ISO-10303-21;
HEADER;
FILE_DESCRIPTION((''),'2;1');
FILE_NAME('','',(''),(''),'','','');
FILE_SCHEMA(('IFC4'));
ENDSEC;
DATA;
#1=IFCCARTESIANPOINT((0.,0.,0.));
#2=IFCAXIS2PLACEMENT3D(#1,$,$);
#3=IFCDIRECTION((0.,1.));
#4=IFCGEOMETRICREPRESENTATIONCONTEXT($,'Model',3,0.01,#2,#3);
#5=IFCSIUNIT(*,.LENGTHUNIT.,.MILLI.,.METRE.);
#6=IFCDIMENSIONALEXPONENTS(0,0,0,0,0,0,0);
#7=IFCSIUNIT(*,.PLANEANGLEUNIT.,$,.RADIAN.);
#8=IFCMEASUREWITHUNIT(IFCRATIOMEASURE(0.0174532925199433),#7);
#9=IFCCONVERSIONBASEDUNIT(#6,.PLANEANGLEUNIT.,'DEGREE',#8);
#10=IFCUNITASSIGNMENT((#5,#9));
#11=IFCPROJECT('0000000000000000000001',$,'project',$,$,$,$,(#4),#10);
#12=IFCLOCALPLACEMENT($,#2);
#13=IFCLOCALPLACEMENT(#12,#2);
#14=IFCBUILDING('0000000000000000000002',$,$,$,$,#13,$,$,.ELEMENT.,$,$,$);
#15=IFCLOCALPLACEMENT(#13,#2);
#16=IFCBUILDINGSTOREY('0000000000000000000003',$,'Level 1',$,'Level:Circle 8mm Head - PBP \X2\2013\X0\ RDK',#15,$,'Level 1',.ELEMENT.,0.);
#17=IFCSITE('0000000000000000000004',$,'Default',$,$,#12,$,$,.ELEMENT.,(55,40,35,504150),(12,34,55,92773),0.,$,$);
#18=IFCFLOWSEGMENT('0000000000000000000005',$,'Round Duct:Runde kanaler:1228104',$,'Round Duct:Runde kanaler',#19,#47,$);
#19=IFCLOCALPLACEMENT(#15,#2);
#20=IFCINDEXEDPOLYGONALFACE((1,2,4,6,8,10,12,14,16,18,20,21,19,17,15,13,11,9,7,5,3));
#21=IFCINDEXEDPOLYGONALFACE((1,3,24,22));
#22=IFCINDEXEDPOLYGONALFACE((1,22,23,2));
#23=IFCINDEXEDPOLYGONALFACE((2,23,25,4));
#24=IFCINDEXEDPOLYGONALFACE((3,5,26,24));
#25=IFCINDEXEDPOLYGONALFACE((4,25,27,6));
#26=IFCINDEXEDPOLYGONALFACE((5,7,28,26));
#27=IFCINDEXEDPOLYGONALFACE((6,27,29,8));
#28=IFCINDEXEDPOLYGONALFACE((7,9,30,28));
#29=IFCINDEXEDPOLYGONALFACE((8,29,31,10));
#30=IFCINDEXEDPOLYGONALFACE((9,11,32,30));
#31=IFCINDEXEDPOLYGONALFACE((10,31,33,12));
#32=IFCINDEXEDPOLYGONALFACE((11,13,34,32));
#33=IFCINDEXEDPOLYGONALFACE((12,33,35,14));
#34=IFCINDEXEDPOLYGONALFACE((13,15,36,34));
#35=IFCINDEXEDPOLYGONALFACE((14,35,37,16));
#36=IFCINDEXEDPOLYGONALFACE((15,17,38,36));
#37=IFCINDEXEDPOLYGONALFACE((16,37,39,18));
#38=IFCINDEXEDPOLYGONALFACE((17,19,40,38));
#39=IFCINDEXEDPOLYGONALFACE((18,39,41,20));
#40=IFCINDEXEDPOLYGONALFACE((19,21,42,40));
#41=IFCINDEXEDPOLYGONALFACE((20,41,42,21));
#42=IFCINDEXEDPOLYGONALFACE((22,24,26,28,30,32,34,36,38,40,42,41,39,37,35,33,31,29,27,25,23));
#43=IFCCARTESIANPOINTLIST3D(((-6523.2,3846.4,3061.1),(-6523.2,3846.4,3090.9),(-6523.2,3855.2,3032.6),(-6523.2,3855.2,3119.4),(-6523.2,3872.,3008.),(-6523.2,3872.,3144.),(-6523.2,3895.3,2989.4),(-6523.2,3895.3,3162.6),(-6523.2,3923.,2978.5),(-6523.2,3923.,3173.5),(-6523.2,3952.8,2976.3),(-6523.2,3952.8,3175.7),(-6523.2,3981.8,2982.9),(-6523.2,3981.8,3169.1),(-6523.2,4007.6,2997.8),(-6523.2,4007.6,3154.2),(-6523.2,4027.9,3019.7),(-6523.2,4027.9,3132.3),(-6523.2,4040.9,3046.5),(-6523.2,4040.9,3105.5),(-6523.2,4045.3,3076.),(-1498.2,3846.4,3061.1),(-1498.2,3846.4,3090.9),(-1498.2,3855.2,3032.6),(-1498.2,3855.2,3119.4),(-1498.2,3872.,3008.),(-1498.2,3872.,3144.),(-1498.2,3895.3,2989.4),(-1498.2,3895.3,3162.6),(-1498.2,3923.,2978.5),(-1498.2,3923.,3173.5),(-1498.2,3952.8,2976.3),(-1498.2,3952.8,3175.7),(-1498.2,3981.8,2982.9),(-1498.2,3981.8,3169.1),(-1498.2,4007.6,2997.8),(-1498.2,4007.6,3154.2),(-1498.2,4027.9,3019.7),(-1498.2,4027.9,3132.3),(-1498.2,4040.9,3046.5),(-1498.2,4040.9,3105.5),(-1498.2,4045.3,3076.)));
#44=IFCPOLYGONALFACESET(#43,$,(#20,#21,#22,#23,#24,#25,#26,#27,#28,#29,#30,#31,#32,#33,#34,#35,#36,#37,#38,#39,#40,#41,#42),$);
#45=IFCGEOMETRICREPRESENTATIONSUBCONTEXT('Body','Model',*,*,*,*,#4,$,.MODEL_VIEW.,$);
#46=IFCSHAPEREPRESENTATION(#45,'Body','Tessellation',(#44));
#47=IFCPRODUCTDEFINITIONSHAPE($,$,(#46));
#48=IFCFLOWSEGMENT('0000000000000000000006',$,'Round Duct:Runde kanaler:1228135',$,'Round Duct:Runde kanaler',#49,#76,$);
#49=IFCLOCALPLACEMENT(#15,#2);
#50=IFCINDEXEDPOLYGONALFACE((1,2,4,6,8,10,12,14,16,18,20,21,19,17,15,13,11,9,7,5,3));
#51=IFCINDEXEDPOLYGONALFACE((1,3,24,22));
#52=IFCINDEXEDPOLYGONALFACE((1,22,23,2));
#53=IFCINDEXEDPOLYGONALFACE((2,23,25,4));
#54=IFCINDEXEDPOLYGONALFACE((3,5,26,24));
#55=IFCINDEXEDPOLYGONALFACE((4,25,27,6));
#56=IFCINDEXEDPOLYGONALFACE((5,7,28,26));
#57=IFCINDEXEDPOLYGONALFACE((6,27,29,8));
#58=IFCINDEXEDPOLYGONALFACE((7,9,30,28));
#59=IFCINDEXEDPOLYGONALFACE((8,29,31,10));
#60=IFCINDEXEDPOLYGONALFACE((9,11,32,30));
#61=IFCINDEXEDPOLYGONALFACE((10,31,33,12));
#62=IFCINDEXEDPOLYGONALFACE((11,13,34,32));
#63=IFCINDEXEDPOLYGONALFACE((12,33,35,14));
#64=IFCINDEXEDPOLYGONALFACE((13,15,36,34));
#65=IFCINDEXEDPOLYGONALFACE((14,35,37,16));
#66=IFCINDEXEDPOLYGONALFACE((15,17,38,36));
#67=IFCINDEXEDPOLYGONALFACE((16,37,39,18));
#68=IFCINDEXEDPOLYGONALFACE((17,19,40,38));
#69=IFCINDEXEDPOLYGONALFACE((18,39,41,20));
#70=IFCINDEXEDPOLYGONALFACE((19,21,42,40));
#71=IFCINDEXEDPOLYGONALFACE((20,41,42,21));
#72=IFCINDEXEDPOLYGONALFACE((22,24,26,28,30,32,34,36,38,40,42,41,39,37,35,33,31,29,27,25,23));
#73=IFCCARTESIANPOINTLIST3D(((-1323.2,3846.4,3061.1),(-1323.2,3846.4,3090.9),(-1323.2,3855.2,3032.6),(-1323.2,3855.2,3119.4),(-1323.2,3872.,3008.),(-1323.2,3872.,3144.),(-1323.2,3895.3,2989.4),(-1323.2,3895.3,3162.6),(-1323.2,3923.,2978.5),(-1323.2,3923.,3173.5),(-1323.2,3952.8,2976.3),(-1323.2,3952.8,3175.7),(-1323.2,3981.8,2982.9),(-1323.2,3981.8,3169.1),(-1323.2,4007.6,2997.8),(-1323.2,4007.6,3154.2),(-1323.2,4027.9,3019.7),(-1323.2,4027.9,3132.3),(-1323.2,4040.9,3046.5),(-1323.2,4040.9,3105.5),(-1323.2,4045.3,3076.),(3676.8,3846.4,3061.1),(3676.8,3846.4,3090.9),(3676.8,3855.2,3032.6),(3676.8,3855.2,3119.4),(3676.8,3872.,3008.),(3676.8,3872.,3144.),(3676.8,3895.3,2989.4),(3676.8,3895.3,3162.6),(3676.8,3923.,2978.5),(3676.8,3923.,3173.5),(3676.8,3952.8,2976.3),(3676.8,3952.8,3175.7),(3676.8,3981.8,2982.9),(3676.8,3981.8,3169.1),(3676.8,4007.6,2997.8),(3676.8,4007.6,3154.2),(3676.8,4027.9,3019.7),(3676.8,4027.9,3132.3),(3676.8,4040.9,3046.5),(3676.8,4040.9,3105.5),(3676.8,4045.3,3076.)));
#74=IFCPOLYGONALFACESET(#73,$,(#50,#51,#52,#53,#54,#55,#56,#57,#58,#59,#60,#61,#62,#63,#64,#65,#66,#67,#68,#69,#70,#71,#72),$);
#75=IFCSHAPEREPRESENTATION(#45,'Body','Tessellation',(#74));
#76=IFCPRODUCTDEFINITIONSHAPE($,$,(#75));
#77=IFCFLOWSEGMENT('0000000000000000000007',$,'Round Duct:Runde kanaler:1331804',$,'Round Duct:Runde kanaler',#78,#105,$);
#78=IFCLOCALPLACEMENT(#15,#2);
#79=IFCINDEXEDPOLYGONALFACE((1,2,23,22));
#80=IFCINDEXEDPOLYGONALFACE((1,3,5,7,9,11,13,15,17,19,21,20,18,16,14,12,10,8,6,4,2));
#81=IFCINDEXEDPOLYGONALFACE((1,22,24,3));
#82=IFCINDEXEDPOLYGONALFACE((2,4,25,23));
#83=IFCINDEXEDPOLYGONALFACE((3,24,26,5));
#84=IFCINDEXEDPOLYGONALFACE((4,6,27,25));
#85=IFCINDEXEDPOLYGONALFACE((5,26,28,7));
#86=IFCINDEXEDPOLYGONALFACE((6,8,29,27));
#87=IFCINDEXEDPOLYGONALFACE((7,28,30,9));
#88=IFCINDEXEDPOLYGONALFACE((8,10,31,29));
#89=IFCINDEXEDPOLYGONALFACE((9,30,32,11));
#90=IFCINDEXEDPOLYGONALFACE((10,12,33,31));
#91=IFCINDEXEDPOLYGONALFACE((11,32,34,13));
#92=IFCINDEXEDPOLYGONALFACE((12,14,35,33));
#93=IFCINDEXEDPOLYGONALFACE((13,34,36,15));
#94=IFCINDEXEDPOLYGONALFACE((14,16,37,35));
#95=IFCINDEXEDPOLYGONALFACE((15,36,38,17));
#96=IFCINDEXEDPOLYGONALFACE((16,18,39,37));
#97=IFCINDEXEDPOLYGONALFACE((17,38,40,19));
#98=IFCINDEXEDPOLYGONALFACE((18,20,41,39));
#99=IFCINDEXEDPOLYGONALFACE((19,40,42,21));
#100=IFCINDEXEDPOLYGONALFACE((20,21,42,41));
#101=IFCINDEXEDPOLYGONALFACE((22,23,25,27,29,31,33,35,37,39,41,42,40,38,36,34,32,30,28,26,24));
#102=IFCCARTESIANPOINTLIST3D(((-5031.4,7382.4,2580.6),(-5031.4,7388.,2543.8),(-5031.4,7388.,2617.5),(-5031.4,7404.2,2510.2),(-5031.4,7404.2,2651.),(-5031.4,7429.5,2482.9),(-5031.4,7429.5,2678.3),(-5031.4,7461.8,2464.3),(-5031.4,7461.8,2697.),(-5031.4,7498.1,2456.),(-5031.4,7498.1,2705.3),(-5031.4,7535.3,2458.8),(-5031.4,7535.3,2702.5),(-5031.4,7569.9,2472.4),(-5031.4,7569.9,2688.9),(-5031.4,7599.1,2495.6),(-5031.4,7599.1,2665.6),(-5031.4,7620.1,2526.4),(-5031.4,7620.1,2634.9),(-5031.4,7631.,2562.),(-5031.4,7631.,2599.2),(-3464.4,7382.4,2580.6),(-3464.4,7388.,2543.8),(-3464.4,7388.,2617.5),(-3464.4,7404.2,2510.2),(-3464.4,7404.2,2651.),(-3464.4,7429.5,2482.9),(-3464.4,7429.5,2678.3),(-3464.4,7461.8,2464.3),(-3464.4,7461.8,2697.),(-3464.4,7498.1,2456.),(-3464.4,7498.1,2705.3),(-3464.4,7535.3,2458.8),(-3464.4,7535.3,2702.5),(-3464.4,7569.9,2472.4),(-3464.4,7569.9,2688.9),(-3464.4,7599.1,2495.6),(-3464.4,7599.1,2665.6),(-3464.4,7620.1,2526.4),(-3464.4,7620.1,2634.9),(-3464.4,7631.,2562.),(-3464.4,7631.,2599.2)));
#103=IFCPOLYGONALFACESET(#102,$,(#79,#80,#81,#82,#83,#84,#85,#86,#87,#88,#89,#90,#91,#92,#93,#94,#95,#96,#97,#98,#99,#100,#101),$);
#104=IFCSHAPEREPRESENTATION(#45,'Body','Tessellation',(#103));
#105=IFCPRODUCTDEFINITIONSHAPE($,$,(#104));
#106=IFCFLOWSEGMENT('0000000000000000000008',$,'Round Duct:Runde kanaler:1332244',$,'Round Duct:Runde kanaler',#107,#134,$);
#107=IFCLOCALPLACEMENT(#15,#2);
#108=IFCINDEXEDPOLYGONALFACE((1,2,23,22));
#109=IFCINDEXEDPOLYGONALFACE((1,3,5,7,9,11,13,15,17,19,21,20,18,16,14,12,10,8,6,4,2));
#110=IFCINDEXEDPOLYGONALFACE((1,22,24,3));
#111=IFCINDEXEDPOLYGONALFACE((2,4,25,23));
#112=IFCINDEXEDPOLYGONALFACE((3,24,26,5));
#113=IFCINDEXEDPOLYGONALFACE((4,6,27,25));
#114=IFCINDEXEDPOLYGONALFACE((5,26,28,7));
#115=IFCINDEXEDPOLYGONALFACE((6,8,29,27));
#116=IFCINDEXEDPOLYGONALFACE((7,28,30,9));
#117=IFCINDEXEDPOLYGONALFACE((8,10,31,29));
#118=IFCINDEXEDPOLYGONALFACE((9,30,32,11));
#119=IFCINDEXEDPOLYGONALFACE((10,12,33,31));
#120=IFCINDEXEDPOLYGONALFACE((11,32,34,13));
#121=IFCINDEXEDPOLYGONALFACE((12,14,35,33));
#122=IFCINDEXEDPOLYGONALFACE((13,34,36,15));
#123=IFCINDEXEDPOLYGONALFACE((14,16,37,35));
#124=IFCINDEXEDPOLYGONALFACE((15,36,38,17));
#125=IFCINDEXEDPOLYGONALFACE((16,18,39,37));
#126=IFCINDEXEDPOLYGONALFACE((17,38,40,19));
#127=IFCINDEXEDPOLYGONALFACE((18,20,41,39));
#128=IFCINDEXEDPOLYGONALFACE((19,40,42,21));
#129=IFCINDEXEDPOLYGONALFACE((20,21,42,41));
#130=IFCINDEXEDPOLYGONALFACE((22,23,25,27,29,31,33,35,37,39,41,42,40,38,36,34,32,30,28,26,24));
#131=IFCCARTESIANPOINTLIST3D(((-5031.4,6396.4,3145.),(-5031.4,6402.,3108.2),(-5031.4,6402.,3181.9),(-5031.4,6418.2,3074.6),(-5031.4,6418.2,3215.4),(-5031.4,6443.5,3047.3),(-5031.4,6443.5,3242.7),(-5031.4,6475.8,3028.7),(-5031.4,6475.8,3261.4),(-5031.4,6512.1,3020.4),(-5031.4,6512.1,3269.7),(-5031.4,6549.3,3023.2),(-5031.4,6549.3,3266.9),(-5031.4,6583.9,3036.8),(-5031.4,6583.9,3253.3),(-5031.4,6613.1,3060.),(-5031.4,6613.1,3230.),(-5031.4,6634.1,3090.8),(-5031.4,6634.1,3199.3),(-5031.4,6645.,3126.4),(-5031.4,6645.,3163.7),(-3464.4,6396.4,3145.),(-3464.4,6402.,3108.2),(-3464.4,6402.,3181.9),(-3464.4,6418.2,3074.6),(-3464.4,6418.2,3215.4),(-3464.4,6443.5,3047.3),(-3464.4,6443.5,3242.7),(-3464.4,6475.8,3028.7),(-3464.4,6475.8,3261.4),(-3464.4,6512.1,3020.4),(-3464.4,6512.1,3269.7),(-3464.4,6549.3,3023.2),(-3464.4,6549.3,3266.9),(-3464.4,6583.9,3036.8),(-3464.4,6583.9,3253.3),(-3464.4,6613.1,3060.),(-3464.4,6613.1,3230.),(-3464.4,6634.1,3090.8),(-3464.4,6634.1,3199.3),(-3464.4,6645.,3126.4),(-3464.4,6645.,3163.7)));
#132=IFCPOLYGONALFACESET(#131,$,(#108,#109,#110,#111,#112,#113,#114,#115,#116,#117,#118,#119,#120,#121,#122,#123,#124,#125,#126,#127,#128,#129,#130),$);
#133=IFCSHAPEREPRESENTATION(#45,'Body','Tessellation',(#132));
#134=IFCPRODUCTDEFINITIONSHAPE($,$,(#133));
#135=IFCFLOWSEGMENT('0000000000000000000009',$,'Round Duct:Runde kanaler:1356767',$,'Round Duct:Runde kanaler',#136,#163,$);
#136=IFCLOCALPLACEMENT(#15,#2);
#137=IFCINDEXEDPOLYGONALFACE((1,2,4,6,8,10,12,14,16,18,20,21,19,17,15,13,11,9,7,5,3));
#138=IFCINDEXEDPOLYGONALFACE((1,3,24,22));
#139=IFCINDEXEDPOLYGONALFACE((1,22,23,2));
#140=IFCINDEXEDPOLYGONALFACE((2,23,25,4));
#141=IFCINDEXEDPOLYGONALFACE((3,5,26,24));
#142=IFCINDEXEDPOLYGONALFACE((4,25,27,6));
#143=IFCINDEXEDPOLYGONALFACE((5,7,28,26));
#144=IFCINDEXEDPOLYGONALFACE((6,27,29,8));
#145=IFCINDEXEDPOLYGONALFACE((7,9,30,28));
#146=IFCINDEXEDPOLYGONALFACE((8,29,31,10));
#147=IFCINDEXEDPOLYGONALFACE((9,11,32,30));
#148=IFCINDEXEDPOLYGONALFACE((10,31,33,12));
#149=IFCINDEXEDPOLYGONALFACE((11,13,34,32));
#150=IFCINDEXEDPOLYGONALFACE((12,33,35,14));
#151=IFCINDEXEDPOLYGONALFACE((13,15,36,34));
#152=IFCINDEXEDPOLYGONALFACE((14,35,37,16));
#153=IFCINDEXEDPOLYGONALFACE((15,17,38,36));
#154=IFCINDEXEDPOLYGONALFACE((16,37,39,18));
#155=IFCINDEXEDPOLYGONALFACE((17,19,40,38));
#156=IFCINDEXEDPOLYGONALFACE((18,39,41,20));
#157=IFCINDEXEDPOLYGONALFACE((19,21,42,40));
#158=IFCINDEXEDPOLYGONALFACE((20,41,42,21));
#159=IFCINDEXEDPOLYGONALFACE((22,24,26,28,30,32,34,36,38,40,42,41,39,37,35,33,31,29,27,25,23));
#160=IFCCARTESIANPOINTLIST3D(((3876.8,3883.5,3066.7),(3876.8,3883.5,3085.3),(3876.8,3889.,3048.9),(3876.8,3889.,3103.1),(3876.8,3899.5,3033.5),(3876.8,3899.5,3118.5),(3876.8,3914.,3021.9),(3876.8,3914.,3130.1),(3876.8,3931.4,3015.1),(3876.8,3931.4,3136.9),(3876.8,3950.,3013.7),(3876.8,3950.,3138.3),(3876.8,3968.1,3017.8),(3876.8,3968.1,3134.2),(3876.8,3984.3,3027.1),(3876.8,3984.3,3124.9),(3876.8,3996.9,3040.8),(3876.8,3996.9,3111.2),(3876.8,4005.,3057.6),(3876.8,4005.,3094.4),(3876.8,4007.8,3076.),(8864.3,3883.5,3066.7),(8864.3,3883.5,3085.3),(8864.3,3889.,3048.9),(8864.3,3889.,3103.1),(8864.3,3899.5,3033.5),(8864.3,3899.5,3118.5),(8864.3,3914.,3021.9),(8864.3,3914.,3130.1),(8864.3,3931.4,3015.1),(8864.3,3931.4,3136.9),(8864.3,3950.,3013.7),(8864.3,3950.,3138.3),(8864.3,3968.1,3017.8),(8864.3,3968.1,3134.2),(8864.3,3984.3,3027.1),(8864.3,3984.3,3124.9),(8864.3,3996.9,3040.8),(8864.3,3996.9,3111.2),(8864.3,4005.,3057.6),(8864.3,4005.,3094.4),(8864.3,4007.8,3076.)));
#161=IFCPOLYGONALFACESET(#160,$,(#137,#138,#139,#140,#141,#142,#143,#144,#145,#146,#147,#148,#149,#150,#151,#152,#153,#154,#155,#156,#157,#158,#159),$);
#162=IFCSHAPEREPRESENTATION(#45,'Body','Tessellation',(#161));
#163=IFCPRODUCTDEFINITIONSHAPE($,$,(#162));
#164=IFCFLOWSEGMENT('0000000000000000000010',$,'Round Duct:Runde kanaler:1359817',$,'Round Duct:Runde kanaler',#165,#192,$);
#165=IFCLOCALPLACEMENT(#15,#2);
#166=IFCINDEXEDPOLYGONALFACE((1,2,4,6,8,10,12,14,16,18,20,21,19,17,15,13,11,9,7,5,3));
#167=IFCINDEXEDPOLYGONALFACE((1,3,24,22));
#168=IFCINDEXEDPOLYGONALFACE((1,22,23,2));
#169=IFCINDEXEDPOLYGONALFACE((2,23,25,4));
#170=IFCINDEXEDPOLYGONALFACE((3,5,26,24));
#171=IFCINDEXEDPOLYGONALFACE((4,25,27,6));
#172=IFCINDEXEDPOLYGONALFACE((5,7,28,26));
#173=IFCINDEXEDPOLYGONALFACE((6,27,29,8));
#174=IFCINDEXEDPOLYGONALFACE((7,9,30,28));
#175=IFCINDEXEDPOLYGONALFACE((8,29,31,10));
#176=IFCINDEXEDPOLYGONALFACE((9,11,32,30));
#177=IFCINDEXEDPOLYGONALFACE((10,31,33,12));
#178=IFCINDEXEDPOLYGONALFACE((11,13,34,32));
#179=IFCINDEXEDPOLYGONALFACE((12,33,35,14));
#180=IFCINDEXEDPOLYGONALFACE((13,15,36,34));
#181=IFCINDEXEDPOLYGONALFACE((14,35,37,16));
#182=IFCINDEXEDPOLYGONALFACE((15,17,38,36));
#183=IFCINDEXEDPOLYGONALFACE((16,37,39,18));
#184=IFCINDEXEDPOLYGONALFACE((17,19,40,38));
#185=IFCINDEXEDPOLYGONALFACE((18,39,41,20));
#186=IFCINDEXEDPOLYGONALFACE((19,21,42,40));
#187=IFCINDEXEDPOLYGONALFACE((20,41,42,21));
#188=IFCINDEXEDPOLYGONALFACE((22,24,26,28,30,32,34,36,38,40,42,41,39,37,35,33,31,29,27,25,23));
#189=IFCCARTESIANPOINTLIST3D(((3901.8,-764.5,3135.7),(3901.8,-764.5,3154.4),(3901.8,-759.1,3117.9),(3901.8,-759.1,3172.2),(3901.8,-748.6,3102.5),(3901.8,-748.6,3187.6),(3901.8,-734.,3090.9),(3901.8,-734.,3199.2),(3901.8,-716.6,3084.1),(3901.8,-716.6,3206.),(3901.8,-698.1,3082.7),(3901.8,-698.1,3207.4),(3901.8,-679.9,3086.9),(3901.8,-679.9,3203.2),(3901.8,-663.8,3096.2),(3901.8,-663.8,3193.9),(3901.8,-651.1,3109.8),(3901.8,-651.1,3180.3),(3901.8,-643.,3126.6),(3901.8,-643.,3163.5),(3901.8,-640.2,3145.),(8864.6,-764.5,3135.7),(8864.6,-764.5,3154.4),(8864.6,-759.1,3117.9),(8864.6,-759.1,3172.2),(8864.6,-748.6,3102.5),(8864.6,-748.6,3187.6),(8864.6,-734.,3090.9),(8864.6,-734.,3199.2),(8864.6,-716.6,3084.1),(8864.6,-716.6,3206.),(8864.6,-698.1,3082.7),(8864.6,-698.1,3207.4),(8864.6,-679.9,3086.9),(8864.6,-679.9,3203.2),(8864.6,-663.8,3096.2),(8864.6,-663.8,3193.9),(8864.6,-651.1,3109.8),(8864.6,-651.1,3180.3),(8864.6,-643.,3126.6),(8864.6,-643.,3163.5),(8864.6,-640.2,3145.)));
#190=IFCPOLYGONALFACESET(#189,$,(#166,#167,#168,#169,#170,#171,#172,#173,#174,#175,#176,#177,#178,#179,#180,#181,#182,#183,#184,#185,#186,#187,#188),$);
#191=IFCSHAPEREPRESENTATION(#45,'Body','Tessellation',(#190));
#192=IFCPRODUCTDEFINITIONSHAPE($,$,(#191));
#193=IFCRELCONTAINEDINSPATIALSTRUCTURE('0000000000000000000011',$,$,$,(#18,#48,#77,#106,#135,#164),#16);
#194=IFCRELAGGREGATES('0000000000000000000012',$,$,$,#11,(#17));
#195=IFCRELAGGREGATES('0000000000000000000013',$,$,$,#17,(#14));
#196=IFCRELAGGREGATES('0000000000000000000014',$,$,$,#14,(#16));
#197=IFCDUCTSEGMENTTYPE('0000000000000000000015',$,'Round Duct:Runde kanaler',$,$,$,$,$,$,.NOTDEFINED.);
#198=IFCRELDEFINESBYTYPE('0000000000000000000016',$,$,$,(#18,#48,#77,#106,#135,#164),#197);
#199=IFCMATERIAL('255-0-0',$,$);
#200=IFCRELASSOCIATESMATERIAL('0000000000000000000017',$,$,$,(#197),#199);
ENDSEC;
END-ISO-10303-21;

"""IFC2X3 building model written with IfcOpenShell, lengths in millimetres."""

from ifc_helpers import new_model, entity, si_unit, converted_unit, direction, frame, frame_2d, origin, origin_2d_with_axis, place, context, subcontext, project, spatial, circle, extrude, material, type_object, element, save


model = new_model("IFC2X3")

# Units and contexts
model_context = context("Model", 3, precision=0.01, world=origin(), true_north=direction((0.0, 1.0)))
body_context = subcontext(model_context, "Body", "Model", "MODEL_VIEW")
ifc_project = project(units=[si_unit("LENGTHUNIT", "METRE", prefix="MILLI"), converted_unit("PLANEANGLEUNIT", "DEGREE", entity("IfcRatioMeasure", 0.0174532925199433), si_unit("PLANEANGLEUNIT", "RADIAN"), dimensions=[0, 0, 0, 0, 0, 0, 0])], contexts=[model_context])

# Site, building, storey
site_placement = place(None, origin())
site = spatial("IfcSite", under=ifc_project, at=site_placement, Name="Default", CompositionType="ELEMENT", RefLatitude=(55, 40, 35, 504150), RefLongitude=(12, 34, 55, 92773), RefElevation=0.0)
building_placement = place(site_placement, origin())
building = spatial("IfcBuilding", under=site, at=building_placement, CompositionType="ELEMENT")
storey_placement = place(building_placement, origin())
storey = spatial("IfcBuildingStorey", under=building, at=storey_placement, Name="Level 1", ObjectType="Level:Circle 8mm Head - PBP – RDK", LongName="Level 1", CompositionType="ELEMENT", Elevation=0.0)

# Flow segments
ifc_material_1 = material(Name="255-0-0")
duct_segment_type = type_object("IfcDuctSegmentType", Name="Round Duct:Runde kanaler", PredefinedType="NOTDEFINED", material=ifc_material_1)
flow_segment_1_placement = place(storey_placement, origin())
element("IfcFlowSegment", 1, at=flow_segment_1_placement, inside=storey, type_object=duct_segment_type, Name="Round Duct:Runde kanaler:1228104", ObjectType="Round Duct:Runde kanaler", context=body_context, shape_type="SweptSolid", body=[
    extrude(circle(Radius=100.0, at=origin_2d_with_axis()), frame((-6523.2, 3945.3, 3076.0), z_axis=(1.0, 0.0, 0.0), x_axis=(0.0, 1.0, 0.0)), (0.0, 0.0, 1.0), 5025.0),
])
flow_segment_2_placement = place(storey_placement, origin())
element("IfcFlowSegment", 2, at=flow_segment_2_placement, inside=storey, type_object=duct_segment_type, Name="Round Duct:Runde kanaler:1228135", ObjectType="Round Duct:Runde kanaler", context=body_context, shape_type="SweptSolid", body=[
    extrude(circle(Radius=100.0, at=origin_2d_with_axis()), frame((-1323.2, 3945.3, 3076.0), z_axis=(1.0, 0.0, 0.0), x_axis=(0.0, 1.0, 0.0)), (0.0, 0.0, 1.0), 5000.0),
])
flow_segment_3_placement = place(storey_placement, origin())
element("IfcFlowSegment", 3, at=flow_segment_3_placement, inside=storey, type_object=duct_segment_type, Name="Round Duct:Runde kanaler:1331804", ObjectType="Round Duct:Runde kanaler", context=body_context, shape_type="SweptSolid", body=[
    extrude(circle(Radius=125.0, at=frame_2d((0.0, 0.0), x_axis=(1.0, 0.0))), frame((-5031.4, 7507.4, 2580.6), z_axis=(1.0, 0.0, 0.0), x_axis=(0.0, -1.0, 0.0)), (0.0, 0.0, 1.0), 1567.0),
])
flow_segment_4_placement = place(storey_placement, origin())
element("IfcFlowSegment", 4, at=flow_segment_4_placement, inside=storey, type_object=duct_segment_type, Name="Round Duct:Runde kanaler:1332244", ObjectType="Round Duct:Runde kanaler", context=body_context, shape_type="SweptSolid", body=[
    extrude(circle(Radius=125.0, at=frame_2d((0.0, 0.0), x_axis=(1.0, 0.0))), frame((-5031.4, 6521.4, 3145.0), z_axis=(1.0, 0.0, 0.0), x_axis=(0.0, -1.0, 0.0)), (0.0, 0.0, 1.0), 1567.0),
])
flow_segment_5_placement = place(storey_placement, origin())
element("IfcFlowSegment", 5, at=flow_segment_5_placement, inside=storey, type_object=duct_segment_type, Name="Round Duct:Runde kanaler:1356767", ObjectType="Round Duct:Runde kanaler", context=body_context, shape_type="SweptSolid", body=[
    extrude(circle(Radius=62.5, at=origin_2d_with_axis()), frame((3876.8, 3945.3, 3076.0), z_axis=(1.0, 0.0, 0.0), x_axis=(0.0, 1.0, 0.0)), (0.0, 0.0, 1.0), 4987.5),
])
flow_segment_6_placement = place(storey_placement, origin())
element("IfcFlowSegment", 6, at=flow_segment_6_placement, inside=storey, type_object=duct_segment_type, Name="Round Duct:Runde kanaler:1359817", ObjectType="Round Duct:Runde kanaler", context=body_context, shape_type="SweptSolid", body=[
    extrude(circle(Radius=62.5, at=frame_2d((0.0, 0.0), x_axis=(1.0, 0.0))), frame((3901.8, -702.7, 3145.0), z_axis=(1.0, 0.0, 0.0), x_axis=(0.0, 1.0, 0.0)), (0.0, 0.0, 1.0), 4962.7),
])

save(model, "model.ifc")
